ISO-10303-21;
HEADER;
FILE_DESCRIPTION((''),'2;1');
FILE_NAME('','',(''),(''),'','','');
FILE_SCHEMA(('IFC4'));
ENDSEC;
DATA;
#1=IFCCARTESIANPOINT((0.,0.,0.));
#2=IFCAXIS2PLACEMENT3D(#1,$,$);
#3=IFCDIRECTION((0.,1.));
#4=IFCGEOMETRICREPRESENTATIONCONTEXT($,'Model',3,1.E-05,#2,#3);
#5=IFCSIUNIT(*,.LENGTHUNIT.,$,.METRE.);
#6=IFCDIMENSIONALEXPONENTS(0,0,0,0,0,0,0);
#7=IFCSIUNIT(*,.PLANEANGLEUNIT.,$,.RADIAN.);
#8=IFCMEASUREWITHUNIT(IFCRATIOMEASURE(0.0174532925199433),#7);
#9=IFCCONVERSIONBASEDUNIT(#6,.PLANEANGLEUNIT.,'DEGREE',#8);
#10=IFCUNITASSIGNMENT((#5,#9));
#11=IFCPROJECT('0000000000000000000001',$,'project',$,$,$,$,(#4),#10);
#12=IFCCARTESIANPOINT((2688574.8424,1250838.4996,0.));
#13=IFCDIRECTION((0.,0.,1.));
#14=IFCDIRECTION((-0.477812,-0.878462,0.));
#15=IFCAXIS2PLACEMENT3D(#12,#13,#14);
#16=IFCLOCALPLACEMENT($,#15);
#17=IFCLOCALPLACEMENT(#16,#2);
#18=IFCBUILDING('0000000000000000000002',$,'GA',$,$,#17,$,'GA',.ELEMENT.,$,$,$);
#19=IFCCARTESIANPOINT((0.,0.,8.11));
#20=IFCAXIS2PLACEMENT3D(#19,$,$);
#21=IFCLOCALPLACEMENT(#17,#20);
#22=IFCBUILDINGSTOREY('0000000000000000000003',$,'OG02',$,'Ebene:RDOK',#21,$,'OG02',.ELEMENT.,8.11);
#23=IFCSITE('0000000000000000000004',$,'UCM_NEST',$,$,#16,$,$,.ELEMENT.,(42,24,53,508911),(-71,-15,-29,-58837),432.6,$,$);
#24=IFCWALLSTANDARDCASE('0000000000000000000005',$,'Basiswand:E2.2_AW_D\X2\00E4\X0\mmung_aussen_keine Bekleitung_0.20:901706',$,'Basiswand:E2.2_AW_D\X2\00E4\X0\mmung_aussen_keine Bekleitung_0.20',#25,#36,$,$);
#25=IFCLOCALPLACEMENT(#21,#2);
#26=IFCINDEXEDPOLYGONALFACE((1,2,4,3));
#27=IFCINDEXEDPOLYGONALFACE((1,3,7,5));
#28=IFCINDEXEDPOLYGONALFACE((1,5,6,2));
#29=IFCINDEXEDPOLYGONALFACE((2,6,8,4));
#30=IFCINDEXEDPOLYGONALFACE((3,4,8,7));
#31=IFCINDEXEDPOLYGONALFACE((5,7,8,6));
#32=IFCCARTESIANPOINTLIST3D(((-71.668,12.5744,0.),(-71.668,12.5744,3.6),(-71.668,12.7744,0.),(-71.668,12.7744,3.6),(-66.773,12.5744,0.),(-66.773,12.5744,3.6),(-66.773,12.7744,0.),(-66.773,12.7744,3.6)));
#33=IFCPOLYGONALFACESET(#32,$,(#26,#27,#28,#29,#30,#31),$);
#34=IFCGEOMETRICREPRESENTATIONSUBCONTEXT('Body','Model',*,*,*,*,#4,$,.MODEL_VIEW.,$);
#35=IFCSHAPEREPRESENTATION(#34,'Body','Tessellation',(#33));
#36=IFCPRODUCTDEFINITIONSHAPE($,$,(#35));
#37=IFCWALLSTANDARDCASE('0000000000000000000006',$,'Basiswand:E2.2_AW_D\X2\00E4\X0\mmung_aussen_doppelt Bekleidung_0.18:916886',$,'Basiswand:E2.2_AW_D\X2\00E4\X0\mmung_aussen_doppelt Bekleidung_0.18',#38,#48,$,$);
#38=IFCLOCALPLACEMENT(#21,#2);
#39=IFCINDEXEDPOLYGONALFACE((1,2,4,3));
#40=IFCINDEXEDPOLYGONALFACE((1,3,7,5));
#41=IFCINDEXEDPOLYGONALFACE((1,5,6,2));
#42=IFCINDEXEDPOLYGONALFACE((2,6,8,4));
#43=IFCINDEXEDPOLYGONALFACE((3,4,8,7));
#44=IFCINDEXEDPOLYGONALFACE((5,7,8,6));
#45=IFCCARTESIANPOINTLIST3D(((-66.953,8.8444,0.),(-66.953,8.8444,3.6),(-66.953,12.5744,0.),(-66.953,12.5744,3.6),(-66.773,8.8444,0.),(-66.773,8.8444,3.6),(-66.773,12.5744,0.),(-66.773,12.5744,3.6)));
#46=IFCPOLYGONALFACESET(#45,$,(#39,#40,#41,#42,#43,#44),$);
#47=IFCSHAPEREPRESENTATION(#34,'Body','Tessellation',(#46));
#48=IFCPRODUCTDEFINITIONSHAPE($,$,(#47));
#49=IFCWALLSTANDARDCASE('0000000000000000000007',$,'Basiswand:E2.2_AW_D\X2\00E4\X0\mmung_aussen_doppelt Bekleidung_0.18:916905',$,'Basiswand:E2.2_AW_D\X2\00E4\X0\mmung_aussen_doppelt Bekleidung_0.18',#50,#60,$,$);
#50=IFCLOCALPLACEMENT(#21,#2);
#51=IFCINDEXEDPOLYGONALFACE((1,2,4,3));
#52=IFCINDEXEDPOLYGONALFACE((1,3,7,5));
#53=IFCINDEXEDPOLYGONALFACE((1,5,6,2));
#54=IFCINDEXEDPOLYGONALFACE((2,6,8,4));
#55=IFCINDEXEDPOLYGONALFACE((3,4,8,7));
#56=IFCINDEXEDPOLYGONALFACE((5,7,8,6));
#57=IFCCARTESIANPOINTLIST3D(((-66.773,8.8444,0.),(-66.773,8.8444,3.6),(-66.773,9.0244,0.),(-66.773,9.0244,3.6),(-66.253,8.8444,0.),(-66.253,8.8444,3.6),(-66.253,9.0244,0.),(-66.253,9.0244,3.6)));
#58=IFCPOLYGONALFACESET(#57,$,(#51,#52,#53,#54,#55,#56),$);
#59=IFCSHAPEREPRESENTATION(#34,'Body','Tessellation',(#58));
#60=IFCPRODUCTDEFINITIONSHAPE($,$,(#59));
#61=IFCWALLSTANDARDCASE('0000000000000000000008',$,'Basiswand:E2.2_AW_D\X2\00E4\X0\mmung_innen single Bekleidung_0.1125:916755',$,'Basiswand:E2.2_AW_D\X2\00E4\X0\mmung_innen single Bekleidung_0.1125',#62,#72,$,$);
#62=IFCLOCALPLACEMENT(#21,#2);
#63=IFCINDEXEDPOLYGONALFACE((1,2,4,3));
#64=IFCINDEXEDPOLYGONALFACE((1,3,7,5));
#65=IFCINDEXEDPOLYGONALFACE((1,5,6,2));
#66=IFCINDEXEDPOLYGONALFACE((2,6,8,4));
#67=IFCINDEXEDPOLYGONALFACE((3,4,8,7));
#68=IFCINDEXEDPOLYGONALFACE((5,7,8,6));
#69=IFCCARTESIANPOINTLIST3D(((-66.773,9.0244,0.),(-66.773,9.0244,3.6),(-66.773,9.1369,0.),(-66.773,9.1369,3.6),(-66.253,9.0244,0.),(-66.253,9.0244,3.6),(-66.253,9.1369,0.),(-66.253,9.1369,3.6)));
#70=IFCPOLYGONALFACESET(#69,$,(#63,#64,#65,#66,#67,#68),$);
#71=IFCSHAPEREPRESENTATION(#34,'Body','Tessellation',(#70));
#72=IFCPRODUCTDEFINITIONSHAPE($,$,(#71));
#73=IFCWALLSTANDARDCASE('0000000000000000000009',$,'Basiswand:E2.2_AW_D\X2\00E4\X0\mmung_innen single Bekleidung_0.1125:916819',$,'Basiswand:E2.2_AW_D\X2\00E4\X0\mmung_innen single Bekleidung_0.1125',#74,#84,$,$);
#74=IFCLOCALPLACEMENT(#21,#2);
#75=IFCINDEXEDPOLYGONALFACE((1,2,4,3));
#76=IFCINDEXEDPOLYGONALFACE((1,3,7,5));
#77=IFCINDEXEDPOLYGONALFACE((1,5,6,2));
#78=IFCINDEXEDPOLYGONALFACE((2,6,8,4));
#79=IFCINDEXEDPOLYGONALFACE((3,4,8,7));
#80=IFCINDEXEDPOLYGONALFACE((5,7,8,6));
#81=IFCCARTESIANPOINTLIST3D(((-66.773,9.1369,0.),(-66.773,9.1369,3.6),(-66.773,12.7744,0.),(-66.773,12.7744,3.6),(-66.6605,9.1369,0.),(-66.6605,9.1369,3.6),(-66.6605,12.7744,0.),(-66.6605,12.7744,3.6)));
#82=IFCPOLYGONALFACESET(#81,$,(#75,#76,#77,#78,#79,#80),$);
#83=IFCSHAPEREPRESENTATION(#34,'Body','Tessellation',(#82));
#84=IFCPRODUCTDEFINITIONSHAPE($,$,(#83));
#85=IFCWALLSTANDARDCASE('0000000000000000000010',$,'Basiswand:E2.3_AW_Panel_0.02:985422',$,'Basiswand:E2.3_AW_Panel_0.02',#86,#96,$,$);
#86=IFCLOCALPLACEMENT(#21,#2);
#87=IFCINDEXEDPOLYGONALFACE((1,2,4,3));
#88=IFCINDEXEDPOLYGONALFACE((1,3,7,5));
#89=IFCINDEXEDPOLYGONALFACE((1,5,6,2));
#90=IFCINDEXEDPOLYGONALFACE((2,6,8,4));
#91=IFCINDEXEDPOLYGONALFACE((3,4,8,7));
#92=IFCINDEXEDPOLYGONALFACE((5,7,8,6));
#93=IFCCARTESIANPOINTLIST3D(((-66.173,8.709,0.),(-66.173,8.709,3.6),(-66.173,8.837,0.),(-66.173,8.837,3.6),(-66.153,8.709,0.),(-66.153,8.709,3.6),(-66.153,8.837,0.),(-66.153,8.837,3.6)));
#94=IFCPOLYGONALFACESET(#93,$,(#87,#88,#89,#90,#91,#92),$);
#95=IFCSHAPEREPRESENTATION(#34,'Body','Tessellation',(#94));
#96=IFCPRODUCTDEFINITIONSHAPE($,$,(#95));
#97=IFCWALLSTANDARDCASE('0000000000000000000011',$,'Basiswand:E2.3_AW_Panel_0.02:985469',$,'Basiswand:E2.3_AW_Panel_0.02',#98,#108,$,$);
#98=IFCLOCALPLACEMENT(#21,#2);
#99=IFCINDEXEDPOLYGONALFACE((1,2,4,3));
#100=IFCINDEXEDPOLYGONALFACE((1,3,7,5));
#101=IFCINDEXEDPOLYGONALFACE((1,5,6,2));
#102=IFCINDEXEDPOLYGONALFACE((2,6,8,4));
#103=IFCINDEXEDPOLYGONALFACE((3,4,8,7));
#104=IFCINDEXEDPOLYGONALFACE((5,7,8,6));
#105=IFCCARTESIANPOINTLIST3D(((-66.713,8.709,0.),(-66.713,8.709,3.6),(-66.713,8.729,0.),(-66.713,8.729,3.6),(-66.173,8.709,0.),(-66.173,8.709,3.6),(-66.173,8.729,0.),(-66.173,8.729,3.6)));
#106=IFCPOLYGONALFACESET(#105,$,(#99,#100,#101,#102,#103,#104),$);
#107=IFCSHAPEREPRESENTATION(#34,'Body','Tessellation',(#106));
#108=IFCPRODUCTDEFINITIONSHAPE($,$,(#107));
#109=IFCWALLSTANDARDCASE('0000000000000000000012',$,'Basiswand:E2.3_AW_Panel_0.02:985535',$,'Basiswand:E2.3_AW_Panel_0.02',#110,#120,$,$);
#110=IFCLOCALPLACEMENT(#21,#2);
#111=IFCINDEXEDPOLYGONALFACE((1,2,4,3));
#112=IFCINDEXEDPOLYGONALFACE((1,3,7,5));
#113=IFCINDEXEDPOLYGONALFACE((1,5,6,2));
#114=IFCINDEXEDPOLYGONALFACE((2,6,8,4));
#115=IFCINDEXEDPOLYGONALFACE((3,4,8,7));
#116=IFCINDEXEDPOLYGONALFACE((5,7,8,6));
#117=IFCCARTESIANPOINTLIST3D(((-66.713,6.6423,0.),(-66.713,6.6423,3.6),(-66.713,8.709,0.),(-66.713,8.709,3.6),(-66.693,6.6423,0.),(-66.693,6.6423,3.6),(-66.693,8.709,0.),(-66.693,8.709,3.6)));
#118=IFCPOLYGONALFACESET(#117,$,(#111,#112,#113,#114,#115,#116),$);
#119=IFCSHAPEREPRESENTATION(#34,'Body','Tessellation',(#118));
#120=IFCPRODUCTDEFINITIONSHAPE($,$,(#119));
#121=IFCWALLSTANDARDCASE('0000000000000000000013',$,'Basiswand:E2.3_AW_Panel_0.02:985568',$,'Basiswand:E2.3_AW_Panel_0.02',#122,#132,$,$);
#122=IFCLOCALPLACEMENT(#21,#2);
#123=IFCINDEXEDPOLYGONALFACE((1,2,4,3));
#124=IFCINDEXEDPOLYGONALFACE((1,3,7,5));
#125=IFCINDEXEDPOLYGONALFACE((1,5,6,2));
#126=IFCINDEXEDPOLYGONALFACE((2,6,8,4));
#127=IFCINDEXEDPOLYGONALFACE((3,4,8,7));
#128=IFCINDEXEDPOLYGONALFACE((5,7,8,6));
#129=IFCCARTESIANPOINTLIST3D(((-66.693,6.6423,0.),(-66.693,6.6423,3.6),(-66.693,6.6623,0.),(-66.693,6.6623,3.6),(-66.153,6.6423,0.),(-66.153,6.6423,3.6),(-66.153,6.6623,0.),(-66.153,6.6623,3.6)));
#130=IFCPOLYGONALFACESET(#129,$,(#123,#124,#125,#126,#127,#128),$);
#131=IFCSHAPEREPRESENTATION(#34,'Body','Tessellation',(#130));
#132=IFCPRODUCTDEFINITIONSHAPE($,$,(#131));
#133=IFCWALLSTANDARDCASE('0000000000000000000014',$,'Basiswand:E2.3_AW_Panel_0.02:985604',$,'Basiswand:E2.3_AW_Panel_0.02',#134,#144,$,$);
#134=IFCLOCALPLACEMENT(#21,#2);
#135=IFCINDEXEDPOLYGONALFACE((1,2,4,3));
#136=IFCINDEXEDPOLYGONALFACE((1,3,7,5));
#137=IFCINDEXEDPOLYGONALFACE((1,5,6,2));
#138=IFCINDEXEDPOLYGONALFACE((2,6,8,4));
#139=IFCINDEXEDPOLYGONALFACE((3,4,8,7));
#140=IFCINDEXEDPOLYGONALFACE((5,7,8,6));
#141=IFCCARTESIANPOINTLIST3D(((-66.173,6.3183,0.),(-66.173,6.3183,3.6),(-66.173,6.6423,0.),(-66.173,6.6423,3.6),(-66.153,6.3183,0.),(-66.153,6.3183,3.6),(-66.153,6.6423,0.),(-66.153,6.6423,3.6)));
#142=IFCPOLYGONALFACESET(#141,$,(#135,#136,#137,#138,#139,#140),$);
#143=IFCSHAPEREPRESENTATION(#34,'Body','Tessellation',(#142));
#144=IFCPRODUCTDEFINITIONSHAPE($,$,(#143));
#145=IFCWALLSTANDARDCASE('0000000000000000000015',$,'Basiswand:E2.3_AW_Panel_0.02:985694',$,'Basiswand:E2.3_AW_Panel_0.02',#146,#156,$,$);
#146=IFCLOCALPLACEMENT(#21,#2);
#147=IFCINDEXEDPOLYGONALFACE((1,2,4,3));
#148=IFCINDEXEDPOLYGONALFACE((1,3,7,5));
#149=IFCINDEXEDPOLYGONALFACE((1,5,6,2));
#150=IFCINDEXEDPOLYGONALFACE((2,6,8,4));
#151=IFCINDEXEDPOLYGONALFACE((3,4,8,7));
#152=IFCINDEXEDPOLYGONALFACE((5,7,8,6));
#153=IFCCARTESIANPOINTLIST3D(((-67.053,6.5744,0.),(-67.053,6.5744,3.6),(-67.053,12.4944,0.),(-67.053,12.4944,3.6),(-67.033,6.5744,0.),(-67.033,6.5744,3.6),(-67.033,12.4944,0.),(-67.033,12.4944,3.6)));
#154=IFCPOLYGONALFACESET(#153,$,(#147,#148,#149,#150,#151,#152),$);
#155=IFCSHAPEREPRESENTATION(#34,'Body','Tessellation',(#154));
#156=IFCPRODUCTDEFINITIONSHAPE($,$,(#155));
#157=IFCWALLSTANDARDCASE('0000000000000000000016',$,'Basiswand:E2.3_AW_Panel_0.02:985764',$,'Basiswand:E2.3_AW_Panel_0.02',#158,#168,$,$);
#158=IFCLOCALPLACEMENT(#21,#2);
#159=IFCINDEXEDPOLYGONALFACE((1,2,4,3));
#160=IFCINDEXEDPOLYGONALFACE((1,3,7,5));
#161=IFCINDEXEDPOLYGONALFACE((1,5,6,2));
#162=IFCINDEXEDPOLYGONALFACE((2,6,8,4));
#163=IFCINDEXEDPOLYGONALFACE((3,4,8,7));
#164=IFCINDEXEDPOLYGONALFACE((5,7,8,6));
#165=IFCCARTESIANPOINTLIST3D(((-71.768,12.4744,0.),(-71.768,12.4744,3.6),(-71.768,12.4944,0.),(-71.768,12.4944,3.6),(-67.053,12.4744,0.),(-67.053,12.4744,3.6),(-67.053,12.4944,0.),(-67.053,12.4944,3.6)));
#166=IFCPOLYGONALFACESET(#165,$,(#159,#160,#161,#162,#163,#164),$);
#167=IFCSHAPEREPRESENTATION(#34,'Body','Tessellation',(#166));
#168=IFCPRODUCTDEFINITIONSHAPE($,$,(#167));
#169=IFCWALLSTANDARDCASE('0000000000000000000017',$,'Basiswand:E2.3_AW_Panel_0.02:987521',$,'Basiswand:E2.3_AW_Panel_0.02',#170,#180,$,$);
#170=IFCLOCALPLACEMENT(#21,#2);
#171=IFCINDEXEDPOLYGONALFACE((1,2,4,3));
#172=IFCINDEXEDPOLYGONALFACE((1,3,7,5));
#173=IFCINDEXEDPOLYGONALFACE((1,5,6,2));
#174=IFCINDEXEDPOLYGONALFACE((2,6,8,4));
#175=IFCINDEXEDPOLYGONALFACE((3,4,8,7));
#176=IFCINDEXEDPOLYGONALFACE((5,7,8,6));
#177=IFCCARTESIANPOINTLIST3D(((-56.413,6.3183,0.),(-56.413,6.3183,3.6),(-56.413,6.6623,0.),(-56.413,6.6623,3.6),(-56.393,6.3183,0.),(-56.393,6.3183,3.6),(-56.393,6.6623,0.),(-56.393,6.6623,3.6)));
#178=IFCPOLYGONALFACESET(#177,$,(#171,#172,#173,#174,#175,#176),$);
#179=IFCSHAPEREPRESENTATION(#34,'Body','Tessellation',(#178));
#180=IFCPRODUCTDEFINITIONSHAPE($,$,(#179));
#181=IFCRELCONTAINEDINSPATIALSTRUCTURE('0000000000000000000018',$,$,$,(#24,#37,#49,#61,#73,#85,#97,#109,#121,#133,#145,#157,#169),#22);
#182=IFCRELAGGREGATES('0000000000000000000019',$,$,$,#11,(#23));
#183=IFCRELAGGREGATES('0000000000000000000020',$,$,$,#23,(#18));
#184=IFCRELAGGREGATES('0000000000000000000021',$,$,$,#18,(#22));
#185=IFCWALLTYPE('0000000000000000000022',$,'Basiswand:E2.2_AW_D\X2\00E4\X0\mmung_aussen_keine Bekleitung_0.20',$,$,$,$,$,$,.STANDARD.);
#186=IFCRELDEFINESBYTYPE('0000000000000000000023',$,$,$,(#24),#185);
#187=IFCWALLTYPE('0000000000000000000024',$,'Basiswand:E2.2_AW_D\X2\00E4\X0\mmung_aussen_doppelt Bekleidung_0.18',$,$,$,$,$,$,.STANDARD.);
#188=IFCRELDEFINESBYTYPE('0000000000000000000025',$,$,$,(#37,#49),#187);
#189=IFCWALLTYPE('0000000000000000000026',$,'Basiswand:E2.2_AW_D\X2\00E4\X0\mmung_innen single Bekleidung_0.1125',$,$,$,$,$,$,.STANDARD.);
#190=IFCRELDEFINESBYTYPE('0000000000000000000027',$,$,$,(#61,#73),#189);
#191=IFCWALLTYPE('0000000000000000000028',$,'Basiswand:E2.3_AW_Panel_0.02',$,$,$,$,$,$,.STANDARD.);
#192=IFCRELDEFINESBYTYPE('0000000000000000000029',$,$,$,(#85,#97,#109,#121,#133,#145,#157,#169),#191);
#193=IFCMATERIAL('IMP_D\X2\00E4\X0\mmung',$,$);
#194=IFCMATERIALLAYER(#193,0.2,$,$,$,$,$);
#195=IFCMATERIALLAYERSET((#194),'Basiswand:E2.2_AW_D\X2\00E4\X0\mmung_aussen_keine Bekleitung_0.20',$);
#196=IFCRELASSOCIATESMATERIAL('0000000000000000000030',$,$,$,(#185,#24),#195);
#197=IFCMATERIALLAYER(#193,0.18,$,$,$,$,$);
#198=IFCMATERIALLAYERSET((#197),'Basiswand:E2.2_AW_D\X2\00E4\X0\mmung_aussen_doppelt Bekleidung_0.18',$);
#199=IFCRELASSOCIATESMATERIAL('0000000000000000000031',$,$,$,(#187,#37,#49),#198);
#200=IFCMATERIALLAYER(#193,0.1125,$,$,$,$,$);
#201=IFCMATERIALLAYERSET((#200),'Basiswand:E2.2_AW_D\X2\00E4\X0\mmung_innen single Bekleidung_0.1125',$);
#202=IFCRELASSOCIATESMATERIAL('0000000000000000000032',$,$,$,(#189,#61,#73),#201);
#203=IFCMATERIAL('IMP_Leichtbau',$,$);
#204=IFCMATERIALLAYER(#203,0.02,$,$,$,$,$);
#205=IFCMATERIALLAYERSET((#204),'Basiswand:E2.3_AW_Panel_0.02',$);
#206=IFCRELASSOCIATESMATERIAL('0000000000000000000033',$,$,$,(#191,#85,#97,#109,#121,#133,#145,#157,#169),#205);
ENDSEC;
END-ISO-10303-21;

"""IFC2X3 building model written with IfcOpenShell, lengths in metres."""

from ifc_helpers import new_model, entity, si_unit, converted_unit, direction, frame, frame_2d, origin, place, context, subcontext, project, spatial, rectangle, extrude, material, layer, layer_set, layer_usage, type_object, element, save


model = new_model("IFC2X3")

# Units and contexts
model_context = context("Model", 3, precision=1e-05, world=origin(), true_north=direction((0.0, 1.0)))
body_context = subcontext(model_context, "Body", "Model", "MODEL_VIEW")
ifc_project = project(units=[si_unit("LENGTHUNIT", "METRE"), converted_unit("PLANEANGLEUNIT", "DEGREE", entity("IfcRatioMeasure", 0.0174532925199433), si_unit("PLANEANGLEUNIT", "RADIAN"), dimensions=[0, 0, 0, 0, 0, 0, 0])], contexts=[model_context])

# Site, building, storey
site_placement = place(None, frame((2688574.8424, 1250838.4996, 0.0), z_axis=(0.0, 0.0, 1.0), x_axis=(-0.477812, -0.878462, 0.0)))
site = spatial("IfcSite", under=ifc_project, at=site_placement, Name="UCM_NEST", CompositionType="ELEMENT", RefLatitude=(42, 24, 53, 508911), RefLongitude=(-71, -15, -29, -58837), RefElevation=432.6)
building_placement = place(site_placement, origin())
building = spatial("IfcBuilding", under=site, at=building_placement, Name="GA", LongName="GA", CompositionType="ELEMENT")
storey_placement = place(building_placement, frame((0.0, 0.0, 8.11)))
storey = spatial("IfcBuildingStorey", under=building, at=storey_placement, Name="OG02", ObjectType="Ebene:RDOK", LongName="OG02", CompositionType="ELEMENT", Elevation=8.11)

# Walls
ifc_material_1 = material(Name="IMP_Dämmung")
ifc_layer_1 = layer(ifc_material_1, 0.2)
ifc_layer_set_1 = layer_set([ifc_layer_1], Name="Basiswand:E2.2_AW_Dämmung_aussen_keine Bekleitung_0.20")
ifc_layer_usage_1 = layer_usage(ifc_layer_set_1, "AXIS2", "NEGATIVE", 0.1)
wall_type_1 = type_object("IfcWallType", Name="Basiswand:E2.2_AW_Dämmung_aussen_keine Bekleitung_0.20", PredefinedType="STANDARD", material=ifc_layer_set_1)
wall_1_placement = place(storey_placement, frame((-66.773, 12.6744, 0.0), z_axis=(0.0, 0.0, 1.0), x_axis=(-1.0, 0.0, 0.0)))
element("IfcWallStandardCase", 1, at=wall_1_placement, inside=storey, type_object=wall_type_1, material=ifc_layer_usage_1, Name="Basiswand:E2.2_AW_Dämmung_aussen_keine Bekleitung_0.20:901706", ObjectType="Basiswand:E2.2_AW_Dämmung_aussen_keine Bekleitung_0.20", context=body_context, shape_type="SweptSolid", body=[
    extrude(rectangle(XDim=4.895, YDim=0.2, at=frame_2d((2.4475, 0.0), x_axis=(-1.0, 0.0))), origin(), (0.0, 0.0, 1.0), 3.6),
])
ifc_layer_2 = layer(ifc_material_1, 0.18)
ifc_layer_set_2 = layer_set([ifc_layer_2], Name="Basiswand:E2.2_AW_Dämmung_aussen_doppelt Bekleidung_0.18")
ifc_layer_usage_2 = layer_usage(ifc_layer_set_2, "AXIS2", "NEGATIVE", 0.09)
wall_type_2 = type_object("IfcWallType", Name="Basiswand:E2.2_AW_Dämmung_aussen_doppelt Bekleidung_0.18", PredefinedType="STANDARD", material=ifc_layer_set_2)
wall_2_placement = place(storey_placement, frame((-66.863, 12.5744, 0.0), z_axis=(0.0, 0.0, 1.0), x_axis=(0.0, -1.0, 0.0)))
element("IfcWallStandardCase", 2, at=wall_2_placement, inside=storey, type_object=wall_type_2, material=ifc_layer_usage_2, Name="Basiswand:E2.2_AW_Dämmung_aussen_doppelt Bekleidung_0.18:916886", ObjectType="Basiswand:E2.2_AW_Dämmung_aussen_doppelt Bekleidung_0.18", context=body_context, shape_type="SweptSolid", body=[
    extrude(rectangle(XDim=3.73, YDim=0.18, at=frame_2d((1.865, 0.0), x_axis=(-1.0, 0.0))), origin(), (0.0, 0.0, 1.0), 3.6),
])
ifc_layer_usage_3 = layer_usage(ifc_layer_set_2, "AXIS2", "NEGATIVE", 0.09)
wall_3_placement = place(storey_placement, frame((-66.773, 8.9344, 0.0)))
element("IfcWallStandardCase", 3, at=wall_3_placement, inside=storey, type_object=wall_type_2, material=ifc_layer_usage_3, Name="Basiswand:E2.2_AW_Dämmung_aussen_doppelt Bekleidung_0.18:916905", ObjectType="Basiswand:E2.2_AW_Dämmung_aussen_doppelt Bekleidung_0.18", context=body_context, shape_type="SweptSolid", body=[
    extrude(rectangle(XDim=0.52, YDim=0.18, at=frame_2d((0.26, 0.0), x_axis=(-1.0, 0.0))), origin(), (0.0, 0.0, 1.0), 3.6),
])
ifc_layer_3 = layer(ifc_material_1, 0.1125)
ifc_layer_set_3 = layer_set([ifc_layer_3], Name="Basiswand:E2.2_AW_Dämmung_innen single Bekleidung_0.1125")
ifc_layer_usage_4 = layer_usage(ifc_layer_set_3, "AXIS2", "NEGATIVE", 0.0563)
wall_type_3 = type_object("IfcWallType", Name="Basiswand:E2.2_AW_Dämmung_innen single Bekleidung_0.1125", PredefinedType="STANDARD", material=ifc_layer_set_3)
wall_4_placement = place(storey_placement, frame((-66.253, 9.0807, 0.0), z_axis=(0.0, 0.0, 1.0), x_axis=(-1.0, 0.0, 0.0)))
element("IfcWallStandardCase", 4, at=wall_4_placement, inside=storey, type_object=wall_type_3, material=ifc_layer_usage_4, Name="Basiswand:E2.2_AW_Dämmung_innen single Bekleidung_0.1125:916755", ObjectType="Basiswand:E2.2_AW_Dämmung_innen single Bekleidung_0.1125", context=body_context, shape_type="SweptSolid", body=[
    extrude(rectangle(XDim=0.52, YDim=0.1125, at=frame_2d((0.26, 0.0), x_axis=(-1.0, 0.0))), origin(), (0.0, 0.0, 1.0), 3.6),
])
ifc_layer_usage_5 = layer_usage(ifc_layer_set_3, "AXIS2", "NEGATIVE", 0.0563)
wall_5_placement = place(storey_placement, frame((-66.7168, 9.1369, 0.0), z_axis=(0.0, 0.0, 1.0), x_axis=(0.0, 1.0, 0.0)))
element("IfcWallStandardCase", 5, at=wall_5_placement, inside=storey, type_object=wall_type_3, material=ifc_layer_usage_5, Name="Basiswand:E2.2_AW_Dämmung_innen single Bekleidung_0.1125:916819", ObjectType="Basiswand:E2.2_AW_Dämmung_innen single Bekleidung_0.1125", context=body_context, shape_type="SweptSolid", body=[
    extrude(rectangle(XDim=3.6375, YDim=0.1125, at=frame_2d((1.8187, 0.0), x_axis=(-1.0, 0.0))), origin(), (0.0, 0.0, 1.0), 3.6),
])
ifc_material_2 = material(Name="IMP_Leichtbau")
ifc_layer_4 = layer(ifc_material_2, 0.02)
ifc_layer_set_4 = layer_set([ifc_layer_4], Name="Basiswand:E2.3_AW_Panel_0.02")
ifc_layer_usage_6 = layer_usage(ifc_layer_set_4, "AXIS2", "NEGATIVE", 0.01)
wall_type_4 = type_object("IfcWallType", Name="Basiswand:E2.3_AW_Panel_0.02", PredefinedType="STANDARD", material=ifc_layer_set_4)
wall_6_placement = place(storey_placement, frame((-66.163, 8.837, 0.0), z_axis=(0.0, 0.0, 1.0), x_axis=(0.0, -1.0, 0.0)))
element("IfcWallStandardCase", 6, at=wall_6_placement, inside=storey, type_object=wall_type_4, material=ifc_layer_usage_6, Name="Basiswand:E2.3_AW_Panel_0.02:985422", ObjectType="Basiswand:E2.3_AW_Panel_0.02", context=body_context, shape_type="SweptSolid", body=[
    extrude(rectangle(XDim=0.128, YDim=0.02, at=frame_2d((0.064, 0.0), x_axis=(-1.0, 0.0))), origin(), (0.0, 0.0, 1.0), 3.6),
])
ifc_layer_usage_7 = layer_usage(ifc_layer_set_4, "AXIS2", "NEGATIVE", 0.01)
wall_7_placement = place(storey_placement, frame((-66.173, 8.719, 0.0), z_axis=(0.0, 0.0, 1.0), x_axis=(-1.0, 0.0, 0.0)))
element("IfcWallStandardCase", 7, at=wall_7_placement, inside=storey, type_object=wall_type_4, material=ifc_layer_usage_7, Name="Basiswand:E2.3_AW_Panel_0.02:985469", ObjectType="Basiswand:E2.3_AW_Panel_0.02", context=body_context, shape_type="SweptSolid", body=[
    extrude(rectangle(XDim=0.54, YDim=0.02, at=frame_2d((0.27, 0.0), x_axis=(-1.0, 0.0))), origin(), (0.0, 0.0, 1.0), 3.6),
])
ifc_layer_usage_8 = layer_usage(ifc_layer_set_4, "AXIS2", "NEGATIVE", 0.01)
wall_8_placement = place(storey_placement, frame((-66.703, 8.709, 0.0), z_axis=(0.0, 0.0, 1.0), x_axis=(0.0, -1.0, 0.0)))
element("IfcWallStandardCase", 8, at=wall_8_placement, inside=storey, type_object=wall_type_4, material=ifc_layer_usage_8, Name="Basiswand:E2.3_AW_Panel_0.02:985535", ObjectType="Basiswand:E2.3_AW_Panel_0.02", context=body_context, shape_type="SweptSolid", body=[
    extrude(rectangle(XDim=2.0667, YDim=0.02, at=frame_2d((1.0333, 0.0), x_axis=(-1.0, 0.0))), origin(), (0.0, 0.0, 1.0), 3.6),
])
ifc_layer_usage_9 = layer_usage(ifc_layer_set_4, "AXIS2", "NEGATIVE", 0.01)
wall_9_placement = place(storey_placement, frame((-66.693, 6.6523, 0.0)))
element("IfcWallStandardCase", 9, at=wall_9_placement, inside=storey, type_object=wall_type_4, material=ifc_layer_usage_9, Name="Basiswand:E2.3_AW_Panel_0.02:985568", ObjectType="Basiswand:E2.3_AW_Panel_0.02", context=body_context, shape_type="SweptSolid", body=[
    extrude(rectangle(XDim=0.54, YDim=0.02, at=frame_2d((0.27, 0.0), x_axis=(-1.0, 0.0))), origin(), (0.0, 0.0, 1.0), 3.6),
])
ifc_layer_usage_10 = layer_usage(ifc_layer_set_4, "AXIS2", "NEGATIVE", 0.01)
wall_10_placement = place(storey_placement, frame((-66.163, 6.6423, 0.0), z_axis=(0.0, 0.0, 1.0), x_axis=(0.0, -1.0, 0.0)))
element("IfcWallStandardCase", 10, at=wall_10_placement, inside=storey, type_object=wall_type_4, material=ifc_layer_usage_10, Name="Basiswand:E2.3_AW_Panel_0.02:985604", ObjectType="Basiswand:E2.3_AW_Panel_0.02", context=body_context, shape_type="SweptSolid", body=[
    extrude(rectangle(XDim=0.324, YDim=0.02, at=frame_2d((0.162, 0.0), x_axis=(-1.0, 0.0))), origin(), (0.0, 0.0, 1.0), 3.6),
])
ifc_layer_usage_11 = layer_usage(ifc_layer_set_4, "AXIS2", "NEGATIVE", 0.01)
wall_11_placement = place(storey_placement, frame((-67.043, 6.5744, 0.0), z_axis=(0.0, 0.0, 1.0), x_axis=(0.0, 1.0, 0.0)))
element("IfcWallStandardCase", 11, at=wall_11_placement, inside=storey, type_object=wall_type_4, material=ifc_layer_usage_11, Name="Basiswand:E2.3_AW_Panel_0.02:985694", ObjectType="Basiswand:E2.3_AW_Panel_0.02", context=body_context, shape_type="SweptSolid", body=[
    extrude(rectangle(XDim=5.92, YDim=0.02, at=frame_2d((2.96, 0.0), x_axis=(-1.0, 0.0))), origin(), (0.0, 0.0, 1.0), 3.6),
])
ifc_layer_usage_12 = layer_usage(ifc_layer_set_4, "AXIS2", "NEGATIVE", 0.01)
wall_12_placement = place(storey_placement, frame((-67.053, 12.4844, 0.0), z_axis=(0.0, 0.0, 1.0), x_axis=(-1.0, 0.0, 0.0)))
element("IfcWallStandardCase", 12, at=wall_12_placement, inside=storey, type_object=wall_type_4, material=ifc_layer_usage_12, Name="Basiswand:E2.3_AW_Panel_0.02:985764", ObjectType="Basiswand:E2.3_AW_Panel_0.02", context=body_context, shape_type="SweptSolid", body=[
    extrude(rectangle(XDim=4.715, YDim=0.02, at=frame_2d((2.3575, 0.0), x_axis=(-1.0, 0.0))), origin(), (0.0, 0.0, 1.0), 3.6),
])
ifc_layer_usage_13 = layer_usage(ifc_layer_set_4, "AXIS2", "NEGATIVE", 0.01)
wall_13_placement = place(storey_placement, frame((-56.403, 6.3183, 0.0), z_axis=(0.0, 0.0, 1.0), x_axis=(0.0, 1.0, 0.0)))
element("IfcWallStandardCase", 13, at=wall_13_placement, inside=storey, type_object=wall_type_4, material=ifc_layer_usage_13, Name="Basiswand:E2.3_AW_Panel_0.02:987521", ObjectType="Basiswand:E2.3_AW_Panel_0.02", context=body_context, shape_type="SweptSolid", body=[
    extrude(rectangle(XDim=0.344, YDim=0.02, at=frame_2d((0.172, 0.0), x_axis=(-1.0, 0.0))), origin(), (0.0, 0.0, 1.0), 3.6),
])

save(model, "model.ifc")
